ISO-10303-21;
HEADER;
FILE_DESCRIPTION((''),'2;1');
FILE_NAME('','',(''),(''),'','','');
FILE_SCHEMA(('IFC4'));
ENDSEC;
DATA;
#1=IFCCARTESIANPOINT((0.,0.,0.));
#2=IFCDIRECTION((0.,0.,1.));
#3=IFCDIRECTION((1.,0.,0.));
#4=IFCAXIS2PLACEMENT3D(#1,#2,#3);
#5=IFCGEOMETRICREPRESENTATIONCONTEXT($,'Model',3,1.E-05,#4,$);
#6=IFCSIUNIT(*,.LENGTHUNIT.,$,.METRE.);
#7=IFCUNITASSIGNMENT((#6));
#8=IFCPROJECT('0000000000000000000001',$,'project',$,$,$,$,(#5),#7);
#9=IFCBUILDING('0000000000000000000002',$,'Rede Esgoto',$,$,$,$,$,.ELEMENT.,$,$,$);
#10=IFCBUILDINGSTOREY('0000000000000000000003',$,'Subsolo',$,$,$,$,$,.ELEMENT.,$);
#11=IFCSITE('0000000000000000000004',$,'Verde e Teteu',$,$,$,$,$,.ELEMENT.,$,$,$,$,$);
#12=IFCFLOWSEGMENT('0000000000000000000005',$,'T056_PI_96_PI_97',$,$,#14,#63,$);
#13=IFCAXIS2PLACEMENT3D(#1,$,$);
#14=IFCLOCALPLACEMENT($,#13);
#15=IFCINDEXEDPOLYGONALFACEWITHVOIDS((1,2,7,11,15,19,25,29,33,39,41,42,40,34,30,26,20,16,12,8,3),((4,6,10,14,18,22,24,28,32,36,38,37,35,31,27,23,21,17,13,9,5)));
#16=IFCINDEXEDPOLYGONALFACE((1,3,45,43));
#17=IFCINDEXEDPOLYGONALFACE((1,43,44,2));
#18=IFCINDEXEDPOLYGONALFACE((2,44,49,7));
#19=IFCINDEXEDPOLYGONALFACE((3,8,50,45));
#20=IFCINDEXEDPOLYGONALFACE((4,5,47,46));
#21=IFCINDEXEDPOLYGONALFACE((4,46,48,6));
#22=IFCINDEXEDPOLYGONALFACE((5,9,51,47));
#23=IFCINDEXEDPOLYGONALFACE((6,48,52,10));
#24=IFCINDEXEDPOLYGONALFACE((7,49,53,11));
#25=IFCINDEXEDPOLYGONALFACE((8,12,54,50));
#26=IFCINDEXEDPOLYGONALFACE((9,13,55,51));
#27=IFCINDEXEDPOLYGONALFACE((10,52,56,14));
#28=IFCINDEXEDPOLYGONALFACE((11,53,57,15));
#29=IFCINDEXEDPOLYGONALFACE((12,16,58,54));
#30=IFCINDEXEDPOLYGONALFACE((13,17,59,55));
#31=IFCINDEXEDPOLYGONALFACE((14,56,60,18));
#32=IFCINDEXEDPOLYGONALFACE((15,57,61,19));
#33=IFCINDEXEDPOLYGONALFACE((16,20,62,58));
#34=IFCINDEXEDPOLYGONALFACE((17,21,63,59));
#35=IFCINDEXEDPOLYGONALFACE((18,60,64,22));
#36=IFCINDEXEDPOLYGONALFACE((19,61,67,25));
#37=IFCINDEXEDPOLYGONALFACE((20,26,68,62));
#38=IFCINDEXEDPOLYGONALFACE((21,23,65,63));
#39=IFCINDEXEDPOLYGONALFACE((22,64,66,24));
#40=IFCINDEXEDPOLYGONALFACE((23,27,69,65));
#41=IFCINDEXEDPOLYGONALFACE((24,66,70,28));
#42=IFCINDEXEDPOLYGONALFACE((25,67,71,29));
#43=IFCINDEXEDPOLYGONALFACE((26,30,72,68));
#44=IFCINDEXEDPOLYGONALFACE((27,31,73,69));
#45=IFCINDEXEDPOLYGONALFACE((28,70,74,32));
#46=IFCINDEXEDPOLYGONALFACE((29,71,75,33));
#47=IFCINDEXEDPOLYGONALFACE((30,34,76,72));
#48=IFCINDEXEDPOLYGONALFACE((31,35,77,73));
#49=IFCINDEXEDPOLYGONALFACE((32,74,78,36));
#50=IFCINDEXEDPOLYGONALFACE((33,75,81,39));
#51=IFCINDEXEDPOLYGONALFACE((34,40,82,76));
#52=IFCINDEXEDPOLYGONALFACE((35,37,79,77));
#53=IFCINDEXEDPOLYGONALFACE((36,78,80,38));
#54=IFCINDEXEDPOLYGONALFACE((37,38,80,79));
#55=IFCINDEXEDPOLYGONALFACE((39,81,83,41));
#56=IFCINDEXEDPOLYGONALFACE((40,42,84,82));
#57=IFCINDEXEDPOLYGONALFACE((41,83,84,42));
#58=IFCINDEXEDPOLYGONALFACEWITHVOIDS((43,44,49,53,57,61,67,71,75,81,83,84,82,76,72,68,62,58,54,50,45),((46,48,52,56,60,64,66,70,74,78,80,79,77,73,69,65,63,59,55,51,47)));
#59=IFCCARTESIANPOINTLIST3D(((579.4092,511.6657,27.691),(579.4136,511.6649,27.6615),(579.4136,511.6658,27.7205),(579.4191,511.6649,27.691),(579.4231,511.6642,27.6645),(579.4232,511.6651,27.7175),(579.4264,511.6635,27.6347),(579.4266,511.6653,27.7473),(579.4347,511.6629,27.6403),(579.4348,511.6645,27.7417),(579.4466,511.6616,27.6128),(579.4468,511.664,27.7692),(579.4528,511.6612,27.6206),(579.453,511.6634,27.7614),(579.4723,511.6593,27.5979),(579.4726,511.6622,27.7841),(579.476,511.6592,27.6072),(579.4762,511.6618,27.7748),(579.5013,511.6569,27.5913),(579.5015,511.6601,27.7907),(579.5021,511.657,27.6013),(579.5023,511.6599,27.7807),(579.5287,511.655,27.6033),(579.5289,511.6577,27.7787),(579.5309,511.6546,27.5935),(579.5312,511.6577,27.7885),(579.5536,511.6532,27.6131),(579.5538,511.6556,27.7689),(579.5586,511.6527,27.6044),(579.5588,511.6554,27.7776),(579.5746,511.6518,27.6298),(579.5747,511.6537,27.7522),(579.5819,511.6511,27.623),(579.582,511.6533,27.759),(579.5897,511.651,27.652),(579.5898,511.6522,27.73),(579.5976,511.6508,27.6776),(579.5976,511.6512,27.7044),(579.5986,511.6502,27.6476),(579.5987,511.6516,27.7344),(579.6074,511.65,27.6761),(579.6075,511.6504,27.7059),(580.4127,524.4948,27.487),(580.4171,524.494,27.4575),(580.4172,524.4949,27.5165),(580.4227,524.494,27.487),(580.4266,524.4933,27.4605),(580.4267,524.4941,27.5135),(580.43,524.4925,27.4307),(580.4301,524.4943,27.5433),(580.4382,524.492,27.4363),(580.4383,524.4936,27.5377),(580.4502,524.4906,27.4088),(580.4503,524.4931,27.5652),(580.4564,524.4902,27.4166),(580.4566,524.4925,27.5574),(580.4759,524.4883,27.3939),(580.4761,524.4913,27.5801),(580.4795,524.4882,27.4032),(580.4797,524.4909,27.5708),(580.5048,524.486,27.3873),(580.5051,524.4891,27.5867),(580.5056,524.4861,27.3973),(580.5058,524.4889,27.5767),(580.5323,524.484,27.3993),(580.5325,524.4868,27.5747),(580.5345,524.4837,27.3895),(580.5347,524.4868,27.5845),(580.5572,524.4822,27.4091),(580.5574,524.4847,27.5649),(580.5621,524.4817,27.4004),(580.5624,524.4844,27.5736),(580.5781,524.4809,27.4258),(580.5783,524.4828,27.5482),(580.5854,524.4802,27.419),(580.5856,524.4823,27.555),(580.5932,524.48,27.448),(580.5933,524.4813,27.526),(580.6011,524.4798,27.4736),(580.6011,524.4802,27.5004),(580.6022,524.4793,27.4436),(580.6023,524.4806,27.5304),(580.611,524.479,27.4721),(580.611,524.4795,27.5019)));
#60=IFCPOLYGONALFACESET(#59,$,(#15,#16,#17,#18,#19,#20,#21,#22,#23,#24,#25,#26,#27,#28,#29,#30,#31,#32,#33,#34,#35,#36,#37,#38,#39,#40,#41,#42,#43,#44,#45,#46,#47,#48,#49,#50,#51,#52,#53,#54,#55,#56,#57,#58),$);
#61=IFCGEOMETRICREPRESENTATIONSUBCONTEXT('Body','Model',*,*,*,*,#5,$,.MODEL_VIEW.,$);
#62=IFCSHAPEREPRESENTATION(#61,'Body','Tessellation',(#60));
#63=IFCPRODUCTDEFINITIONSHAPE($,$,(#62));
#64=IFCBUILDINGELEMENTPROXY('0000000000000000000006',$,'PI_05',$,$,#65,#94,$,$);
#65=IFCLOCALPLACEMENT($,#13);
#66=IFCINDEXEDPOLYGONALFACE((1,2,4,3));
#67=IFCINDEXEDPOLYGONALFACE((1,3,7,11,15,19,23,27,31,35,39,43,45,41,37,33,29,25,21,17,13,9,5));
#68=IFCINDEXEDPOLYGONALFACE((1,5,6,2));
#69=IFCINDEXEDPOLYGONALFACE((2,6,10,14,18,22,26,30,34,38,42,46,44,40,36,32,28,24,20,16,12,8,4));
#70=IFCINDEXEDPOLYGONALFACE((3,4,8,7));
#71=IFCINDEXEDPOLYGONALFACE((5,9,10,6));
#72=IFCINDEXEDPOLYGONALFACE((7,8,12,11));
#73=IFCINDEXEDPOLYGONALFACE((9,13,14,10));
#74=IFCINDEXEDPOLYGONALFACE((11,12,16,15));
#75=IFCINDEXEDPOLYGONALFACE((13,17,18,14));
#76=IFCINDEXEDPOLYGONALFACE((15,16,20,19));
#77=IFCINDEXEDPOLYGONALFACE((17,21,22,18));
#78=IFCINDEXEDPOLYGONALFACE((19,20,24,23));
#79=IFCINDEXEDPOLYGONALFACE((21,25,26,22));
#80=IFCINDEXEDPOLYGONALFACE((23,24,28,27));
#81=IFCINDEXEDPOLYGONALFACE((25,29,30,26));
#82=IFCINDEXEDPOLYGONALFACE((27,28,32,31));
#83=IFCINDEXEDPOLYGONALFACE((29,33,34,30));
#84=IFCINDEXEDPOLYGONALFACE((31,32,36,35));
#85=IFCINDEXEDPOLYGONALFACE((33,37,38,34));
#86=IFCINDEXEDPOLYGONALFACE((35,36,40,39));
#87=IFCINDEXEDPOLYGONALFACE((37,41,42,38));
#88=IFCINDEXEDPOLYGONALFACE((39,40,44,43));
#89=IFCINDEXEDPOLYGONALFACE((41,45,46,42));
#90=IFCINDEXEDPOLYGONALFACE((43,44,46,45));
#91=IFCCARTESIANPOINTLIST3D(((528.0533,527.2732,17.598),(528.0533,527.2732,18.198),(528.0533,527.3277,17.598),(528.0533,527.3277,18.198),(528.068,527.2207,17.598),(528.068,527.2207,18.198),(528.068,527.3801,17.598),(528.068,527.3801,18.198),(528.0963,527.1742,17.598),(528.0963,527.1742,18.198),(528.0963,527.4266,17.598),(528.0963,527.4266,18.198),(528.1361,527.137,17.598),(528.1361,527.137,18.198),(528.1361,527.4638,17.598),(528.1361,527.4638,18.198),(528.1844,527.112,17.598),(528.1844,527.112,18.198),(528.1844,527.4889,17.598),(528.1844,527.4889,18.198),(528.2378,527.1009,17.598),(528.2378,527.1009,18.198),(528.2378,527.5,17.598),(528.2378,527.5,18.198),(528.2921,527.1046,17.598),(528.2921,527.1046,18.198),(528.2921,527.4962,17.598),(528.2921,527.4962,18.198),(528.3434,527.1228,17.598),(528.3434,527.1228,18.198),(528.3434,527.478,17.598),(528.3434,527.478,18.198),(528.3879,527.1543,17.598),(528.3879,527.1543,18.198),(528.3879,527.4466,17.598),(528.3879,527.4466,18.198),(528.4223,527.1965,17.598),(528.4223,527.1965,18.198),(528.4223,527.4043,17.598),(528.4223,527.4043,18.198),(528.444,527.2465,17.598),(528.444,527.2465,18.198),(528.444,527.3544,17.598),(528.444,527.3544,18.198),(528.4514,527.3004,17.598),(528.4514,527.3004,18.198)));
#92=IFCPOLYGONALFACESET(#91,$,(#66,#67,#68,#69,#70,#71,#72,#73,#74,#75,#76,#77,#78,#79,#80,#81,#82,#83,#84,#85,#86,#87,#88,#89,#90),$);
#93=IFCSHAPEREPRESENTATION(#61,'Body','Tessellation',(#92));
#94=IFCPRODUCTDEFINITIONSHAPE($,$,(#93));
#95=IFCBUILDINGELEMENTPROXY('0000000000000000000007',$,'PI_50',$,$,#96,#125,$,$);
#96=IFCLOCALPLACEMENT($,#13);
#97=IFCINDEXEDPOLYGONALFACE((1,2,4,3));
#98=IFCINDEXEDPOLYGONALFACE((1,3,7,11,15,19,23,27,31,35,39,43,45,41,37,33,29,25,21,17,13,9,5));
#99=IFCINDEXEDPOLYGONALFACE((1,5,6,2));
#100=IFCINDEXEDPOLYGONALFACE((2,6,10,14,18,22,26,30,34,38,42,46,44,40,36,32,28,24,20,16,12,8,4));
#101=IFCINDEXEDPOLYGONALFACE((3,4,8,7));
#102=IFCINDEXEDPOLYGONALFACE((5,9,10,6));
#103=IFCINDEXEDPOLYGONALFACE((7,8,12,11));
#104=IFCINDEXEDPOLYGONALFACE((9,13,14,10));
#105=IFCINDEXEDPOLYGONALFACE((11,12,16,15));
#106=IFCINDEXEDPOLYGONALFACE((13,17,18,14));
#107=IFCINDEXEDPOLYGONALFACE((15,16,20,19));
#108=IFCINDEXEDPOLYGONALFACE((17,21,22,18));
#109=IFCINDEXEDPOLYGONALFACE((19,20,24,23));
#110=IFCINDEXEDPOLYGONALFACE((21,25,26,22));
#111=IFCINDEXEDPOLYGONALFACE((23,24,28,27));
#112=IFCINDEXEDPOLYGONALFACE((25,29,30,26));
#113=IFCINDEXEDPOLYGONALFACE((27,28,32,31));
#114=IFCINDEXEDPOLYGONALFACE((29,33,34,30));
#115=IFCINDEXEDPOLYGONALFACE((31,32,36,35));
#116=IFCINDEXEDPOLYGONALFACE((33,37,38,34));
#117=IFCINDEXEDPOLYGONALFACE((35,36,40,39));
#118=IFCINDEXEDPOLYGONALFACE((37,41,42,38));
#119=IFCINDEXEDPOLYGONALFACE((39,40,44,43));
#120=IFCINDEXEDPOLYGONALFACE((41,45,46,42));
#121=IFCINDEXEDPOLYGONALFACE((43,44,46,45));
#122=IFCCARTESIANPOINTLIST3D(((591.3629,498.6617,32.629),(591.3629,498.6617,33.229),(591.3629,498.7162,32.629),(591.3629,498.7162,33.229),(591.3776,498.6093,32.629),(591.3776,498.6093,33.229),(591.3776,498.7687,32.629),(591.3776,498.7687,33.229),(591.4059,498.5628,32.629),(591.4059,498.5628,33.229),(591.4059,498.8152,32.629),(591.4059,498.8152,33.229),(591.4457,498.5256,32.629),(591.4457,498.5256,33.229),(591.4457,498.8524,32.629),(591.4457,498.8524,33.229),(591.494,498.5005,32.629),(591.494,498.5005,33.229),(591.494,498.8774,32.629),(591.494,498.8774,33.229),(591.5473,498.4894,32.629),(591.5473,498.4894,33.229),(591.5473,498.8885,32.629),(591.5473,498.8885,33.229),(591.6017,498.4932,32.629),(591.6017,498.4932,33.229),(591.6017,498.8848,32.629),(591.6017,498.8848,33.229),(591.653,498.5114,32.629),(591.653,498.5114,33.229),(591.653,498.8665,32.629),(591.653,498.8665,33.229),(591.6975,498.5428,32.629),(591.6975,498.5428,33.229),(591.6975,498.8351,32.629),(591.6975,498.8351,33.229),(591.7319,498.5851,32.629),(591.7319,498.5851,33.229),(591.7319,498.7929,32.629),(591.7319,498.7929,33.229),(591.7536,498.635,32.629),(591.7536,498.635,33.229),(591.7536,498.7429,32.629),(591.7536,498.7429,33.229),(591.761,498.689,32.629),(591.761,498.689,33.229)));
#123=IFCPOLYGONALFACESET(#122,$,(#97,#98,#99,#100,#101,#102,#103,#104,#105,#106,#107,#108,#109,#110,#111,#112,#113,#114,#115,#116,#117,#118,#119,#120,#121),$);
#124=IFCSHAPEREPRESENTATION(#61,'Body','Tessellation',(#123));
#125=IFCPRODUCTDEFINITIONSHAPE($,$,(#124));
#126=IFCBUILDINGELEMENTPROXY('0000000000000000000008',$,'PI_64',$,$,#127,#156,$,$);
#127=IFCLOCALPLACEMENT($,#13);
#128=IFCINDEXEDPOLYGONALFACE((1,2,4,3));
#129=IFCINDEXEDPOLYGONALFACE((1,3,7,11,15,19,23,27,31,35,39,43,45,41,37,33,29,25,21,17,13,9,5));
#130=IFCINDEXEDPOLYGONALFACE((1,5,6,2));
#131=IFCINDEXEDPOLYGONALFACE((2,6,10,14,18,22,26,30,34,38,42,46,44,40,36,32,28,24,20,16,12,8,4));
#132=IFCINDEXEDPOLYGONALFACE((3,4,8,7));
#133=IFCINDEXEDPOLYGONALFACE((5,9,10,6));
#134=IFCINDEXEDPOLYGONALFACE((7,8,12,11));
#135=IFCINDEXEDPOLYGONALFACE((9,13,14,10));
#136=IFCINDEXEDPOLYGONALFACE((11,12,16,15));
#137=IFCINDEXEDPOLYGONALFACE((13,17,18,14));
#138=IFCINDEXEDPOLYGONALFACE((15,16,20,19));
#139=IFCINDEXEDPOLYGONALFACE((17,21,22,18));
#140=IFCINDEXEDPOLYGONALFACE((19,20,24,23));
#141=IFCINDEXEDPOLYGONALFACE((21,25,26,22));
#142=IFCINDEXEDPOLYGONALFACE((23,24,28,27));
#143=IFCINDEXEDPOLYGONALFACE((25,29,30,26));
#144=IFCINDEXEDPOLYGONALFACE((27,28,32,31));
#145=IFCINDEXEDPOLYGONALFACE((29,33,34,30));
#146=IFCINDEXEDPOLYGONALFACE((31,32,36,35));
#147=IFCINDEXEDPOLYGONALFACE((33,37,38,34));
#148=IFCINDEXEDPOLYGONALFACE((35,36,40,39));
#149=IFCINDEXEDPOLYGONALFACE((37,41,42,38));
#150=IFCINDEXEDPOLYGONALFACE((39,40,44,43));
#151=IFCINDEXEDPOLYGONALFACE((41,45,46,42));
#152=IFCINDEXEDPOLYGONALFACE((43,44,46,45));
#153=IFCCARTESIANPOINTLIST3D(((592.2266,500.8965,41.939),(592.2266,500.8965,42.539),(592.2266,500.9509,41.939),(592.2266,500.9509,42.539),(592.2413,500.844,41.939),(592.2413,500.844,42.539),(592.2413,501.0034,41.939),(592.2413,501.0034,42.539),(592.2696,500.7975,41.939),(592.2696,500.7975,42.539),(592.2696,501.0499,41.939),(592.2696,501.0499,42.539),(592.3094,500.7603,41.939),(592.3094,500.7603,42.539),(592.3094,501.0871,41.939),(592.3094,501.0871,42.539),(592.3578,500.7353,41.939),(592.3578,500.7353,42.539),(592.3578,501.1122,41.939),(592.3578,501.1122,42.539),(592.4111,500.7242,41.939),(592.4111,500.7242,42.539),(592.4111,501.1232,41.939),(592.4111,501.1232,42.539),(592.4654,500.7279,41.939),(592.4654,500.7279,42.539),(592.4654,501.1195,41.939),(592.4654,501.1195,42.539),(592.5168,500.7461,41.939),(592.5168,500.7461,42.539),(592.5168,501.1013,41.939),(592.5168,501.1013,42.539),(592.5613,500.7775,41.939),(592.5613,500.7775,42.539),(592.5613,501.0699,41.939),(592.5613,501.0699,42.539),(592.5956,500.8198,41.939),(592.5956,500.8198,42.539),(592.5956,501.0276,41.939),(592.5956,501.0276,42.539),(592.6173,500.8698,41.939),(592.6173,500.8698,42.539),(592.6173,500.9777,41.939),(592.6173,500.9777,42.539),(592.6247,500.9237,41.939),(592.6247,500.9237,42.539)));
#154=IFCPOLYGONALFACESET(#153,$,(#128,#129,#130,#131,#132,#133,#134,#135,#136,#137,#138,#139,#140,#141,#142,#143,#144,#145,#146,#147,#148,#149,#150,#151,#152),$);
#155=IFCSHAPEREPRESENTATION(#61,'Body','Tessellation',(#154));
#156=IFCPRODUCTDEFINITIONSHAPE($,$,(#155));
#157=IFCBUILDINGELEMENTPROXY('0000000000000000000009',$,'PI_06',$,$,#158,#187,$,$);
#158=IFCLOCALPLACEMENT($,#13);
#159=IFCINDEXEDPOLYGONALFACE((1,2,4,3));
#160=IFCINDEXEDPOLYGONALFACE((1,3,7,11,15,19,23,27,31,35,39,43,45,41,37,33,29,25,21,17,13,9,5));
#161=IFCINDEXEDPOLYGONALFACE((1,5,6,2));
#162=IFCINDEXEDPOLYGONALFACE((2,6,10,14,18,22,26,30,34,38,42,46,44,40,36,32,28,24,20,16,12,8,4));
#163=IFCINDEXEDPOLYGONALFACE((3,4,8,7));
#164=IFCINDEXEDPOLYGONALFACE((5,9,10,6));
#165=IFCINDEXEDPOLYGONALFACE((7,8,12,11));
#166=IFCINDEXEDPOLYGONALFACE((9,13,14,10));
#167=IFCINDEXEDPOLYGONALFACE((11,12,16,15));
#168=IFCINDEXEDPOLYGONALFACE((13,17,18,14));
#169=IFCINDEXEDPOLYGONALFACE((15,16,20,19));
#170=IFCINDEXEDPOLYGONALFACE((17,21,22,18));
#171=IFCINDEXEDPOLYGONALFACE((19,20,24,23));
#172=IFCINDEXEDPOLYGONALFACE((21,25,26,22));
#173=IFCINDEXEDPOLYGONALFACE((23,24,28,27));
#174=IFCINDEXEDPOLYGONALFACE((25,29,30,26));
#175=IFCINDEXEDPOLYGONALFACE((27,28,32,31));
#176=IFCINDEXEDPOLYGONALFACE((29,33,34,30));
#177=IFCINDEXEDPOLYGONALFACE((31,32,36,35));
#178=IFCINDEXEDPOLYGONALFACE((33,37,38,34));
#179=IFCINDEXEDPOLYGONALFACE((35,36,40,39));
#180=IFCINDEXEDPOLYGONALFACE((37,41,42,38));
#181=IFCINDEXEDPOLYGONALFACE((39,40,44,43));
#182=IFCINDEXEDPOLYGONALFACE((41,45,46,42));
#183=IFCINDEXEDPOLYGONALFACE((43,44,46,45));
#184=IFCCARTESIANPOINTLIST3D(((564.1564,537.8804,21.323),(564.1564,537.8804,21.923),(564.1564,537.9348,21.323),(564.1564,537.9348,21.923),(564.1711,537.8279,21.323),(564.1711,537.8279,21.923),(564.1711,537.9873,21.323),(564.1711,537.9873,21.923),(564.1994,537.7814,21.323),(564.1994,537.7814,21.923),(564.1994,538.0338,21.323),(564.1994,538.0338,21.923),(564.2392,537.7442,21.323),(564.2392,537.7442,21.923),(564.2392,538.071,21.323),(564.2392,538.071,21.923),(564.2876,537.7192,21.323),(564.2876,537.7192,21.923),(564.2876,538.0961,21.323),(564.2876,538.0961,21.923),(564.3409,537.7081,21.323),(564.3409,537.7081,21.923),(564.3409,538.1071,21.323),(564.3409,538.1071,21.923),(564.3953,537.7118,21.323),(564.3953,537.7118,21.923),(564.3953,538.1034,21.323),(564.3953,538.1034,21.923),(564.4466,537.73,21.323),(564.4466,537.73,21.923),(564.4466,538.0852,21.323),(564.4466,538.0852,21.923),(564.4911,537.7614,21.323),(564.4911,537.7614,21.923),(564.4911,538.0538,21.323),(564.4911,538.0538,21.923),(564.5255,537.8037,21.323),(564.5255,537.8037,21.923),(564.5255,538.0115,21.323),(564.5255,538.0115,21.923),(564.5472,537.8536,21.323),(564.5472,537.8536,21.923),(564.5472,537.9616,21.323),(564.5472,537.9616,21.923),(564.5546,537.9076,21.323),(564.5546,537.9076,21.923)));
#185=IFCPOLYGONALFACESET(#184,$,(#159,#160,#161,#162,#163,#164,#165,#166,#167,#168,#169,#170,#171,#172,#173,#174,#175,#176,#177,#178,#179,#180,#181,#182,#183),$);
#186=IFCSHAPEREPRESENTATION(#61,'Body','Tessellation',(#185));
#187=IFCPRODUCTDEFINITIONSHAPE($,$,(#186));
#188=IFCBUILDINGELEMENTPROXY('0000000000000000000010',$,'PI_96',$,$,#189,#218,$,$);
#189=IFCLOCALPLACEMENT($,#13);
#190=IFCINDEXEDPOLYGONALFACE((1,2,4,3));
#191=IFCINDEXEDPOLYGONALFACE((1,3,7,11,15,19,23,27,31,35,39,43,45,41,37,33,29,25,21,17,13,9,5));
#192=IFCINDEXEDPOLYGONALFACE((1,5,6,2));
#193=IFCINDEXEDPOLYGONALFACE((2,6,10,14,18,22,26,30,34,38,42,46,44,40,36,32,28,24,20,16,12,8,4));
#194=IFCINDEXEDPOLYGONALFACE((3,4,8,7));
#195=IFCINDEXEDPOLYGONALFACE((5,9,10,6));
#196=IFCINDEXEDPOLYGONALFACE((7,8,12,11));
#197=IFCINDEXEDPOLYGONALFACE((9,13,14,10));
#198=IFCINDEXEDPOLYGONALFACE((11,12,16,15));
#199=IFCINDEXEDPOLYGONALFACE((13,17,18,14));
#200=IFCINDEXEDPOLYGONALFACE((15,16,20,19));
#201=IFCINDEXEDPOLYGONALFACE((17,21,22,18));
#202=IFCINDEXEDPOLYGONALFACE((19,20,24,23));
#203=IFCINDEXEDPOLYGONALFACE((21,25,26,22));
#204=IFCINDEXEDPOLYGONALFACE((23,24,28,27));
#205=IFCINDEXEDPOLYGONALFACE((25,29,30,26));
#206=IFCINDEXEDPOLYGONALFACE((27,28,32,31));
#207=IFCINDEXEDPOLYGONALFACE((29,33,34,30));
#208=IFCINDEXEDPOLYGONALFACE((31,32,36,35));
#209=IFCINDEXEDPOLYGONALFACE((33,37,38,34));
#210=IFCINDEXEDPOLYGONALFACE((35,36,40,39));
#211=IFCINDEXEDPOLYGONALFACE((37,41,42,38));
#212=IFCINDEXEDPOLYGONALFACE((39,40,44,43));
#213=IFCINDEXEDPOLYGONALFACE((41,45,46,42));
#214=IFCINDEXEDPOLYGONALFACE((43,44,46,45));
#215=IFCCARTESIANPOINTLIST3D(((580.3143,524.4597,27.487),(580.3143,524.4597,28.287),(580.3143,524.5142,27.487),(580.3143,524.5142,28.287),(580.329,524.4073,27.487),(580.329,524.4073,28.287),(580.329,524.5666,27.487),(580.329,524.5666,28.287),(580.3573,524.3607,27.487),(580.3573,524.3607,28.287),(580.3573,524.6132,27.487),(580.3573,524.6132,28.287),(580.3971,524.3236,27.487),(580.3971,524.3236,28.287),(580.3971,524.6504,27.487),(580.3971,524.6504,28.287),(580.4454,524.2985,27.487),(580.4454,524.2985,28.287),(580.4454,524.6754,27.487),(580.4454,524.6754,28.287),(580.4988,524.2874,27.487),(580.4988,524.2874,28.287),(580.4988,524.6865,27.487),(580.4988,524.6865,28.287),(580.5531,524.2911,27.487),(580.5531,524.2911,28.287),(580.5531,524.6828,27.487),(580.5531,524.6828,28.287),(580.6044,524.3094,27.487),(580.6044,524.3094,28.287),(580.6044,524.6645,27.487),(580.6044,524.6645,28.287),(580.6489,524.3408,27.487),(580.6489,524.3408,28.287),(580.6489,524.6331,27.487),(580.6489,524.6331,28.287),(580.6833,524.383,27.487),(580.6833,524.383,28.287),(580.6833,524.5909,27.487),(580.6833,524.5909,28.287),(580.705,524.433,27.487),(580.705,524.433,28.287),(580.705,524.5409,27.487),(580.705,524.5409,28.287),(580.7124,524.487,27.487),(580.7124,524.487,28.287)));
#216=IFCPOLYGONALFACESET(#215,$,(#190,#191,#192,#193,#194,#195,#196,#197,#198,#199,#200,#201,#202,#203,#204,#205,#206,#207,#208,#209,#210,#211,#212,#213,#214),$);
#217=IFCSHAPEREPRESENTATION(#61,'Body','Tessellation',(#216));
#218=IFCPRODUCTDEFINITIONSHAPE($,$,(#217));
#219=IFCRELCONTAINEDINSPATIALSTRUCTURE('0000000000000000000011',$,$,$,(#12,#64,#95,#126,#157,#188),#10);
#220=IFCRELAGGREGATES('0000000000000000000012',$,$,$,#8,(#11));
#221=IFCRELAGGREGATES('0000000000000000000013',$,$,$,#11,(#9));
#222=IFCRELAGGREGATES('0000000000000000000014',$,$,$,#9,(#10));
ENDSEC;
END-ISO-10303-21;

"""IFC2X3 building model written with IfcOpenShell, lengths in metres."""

from ifc_helpers import new_model, entity, si_unit, frame, origin_with_axes, origin_2d, place, context, subcontext, project, spatial, circle, extrude, element, save


model = new_model("IFC2X3")

# Units and contexts
model_context = context("Model", 3, precision=1e-05, world=origin_with_axes())
body_context = subcontext(model_context, "Body", "Model", "MODEL_VIEW")
ifc_project = project(units=[si_unit("LENGTHUNIT", "METRE")], contexts=[model_context])

# Site, building, storey
site = spatial("IfcSite", under=ifc_project, Name="Verde e Teteu", CompositionType="ELEMENT")
building = spatial("IfcBuilding", under=site, Name="Rede Esgoto", CompositionType="ELEMENT")
storey = spatial("IfcBuildingStorey", under=building, Name="Subsolo", CompositionType="ELEMENT")

# Flow segment
flow_segment_1_placement = place(None, frame((580.5124, 524.487, 27.487), z_axis=(0.0, 0.0, 1.0), x_axis=(1.0, 0.0, 0.0)))
element("IfcFlowSegment", 1, at=flow_segment_1_placement, inside=storey, Name="T056_PI_96_PI_97", context=body_context, shape_type="SweptSolid", body=[
    entity("IfcSweptDiskSolid", entity("IfcPolyline", [entity("IfcCartesianPoint", [0.0, 0.0, 0.0]), entity("IfcCartesianPoint", [-1.0035, -12.829, 0.204])]), 0.1, 0.09),
])

# Building element proxies
for number, where, z_axis, x_axis, name in (
    (2, (528.2514, 527.3004, 17.598), (0.0, 0.0, 1.0), (1.0, 0.0, 0.0), "PI_05"),
    (3, (591.561, 498.689, 32.629), (0.0, 0.0, 1.0), (1.0, 0.0, 0.0), "PI_50"),
    (4, (592.4247, 500.9237, 41.939), (0.0, 0.0, 1.0), (1.0, 0.0, 0.0), "PI_64"),
):
    element("IfcBuildingElementProxy", number, at=place(None, frame(where, z_axis=z_axis, x_axis=x_axis)), inside=storey, Name=name, context=body_context, shape_type="SweptSolid", body=[
        extrude(circle(Radius=0.2, at=origin_2d()), origin_with_axes(), (0.0, 0.0, 1.0), 0.6),
    ])
proxy_1_placement = place(None, frame((564.3546, 537.9076, 21.323), z_axis=(0.0, 0.0, 1.0), x_axis=(1.0, 0.0, 0.0)))
element("IfcBuildingElementProxy", 5, at=proxy_1_placement, inside=storey, Name="PI_06", context=body_context, shape_type="SweptSolid", body=[
    extrude(circle(Radius=0.2, at=origin_2d()), origin_with_axes(), (0.0, 0.0, 1.0), 0.6),
])
proxy_2_placement = place(None, frame((580.5124, 524.487, 27.487), z_axis=(0.0, 0.0, 1.0), x_axis=(1.0, 0.0, 0.0)))
element("IfcBuildingElementProxy", 6, at=proxy_2_placement, inside=storey, Name="PI_96", context=body_context, shape_type="SweptSolid", body=[
    extrude(circle(Radius=0.2, at=origin_2d()), origin_with_axes(), (0.0, 0.0, 1.0), 0.8),
])

save(model, "model.ifc")
